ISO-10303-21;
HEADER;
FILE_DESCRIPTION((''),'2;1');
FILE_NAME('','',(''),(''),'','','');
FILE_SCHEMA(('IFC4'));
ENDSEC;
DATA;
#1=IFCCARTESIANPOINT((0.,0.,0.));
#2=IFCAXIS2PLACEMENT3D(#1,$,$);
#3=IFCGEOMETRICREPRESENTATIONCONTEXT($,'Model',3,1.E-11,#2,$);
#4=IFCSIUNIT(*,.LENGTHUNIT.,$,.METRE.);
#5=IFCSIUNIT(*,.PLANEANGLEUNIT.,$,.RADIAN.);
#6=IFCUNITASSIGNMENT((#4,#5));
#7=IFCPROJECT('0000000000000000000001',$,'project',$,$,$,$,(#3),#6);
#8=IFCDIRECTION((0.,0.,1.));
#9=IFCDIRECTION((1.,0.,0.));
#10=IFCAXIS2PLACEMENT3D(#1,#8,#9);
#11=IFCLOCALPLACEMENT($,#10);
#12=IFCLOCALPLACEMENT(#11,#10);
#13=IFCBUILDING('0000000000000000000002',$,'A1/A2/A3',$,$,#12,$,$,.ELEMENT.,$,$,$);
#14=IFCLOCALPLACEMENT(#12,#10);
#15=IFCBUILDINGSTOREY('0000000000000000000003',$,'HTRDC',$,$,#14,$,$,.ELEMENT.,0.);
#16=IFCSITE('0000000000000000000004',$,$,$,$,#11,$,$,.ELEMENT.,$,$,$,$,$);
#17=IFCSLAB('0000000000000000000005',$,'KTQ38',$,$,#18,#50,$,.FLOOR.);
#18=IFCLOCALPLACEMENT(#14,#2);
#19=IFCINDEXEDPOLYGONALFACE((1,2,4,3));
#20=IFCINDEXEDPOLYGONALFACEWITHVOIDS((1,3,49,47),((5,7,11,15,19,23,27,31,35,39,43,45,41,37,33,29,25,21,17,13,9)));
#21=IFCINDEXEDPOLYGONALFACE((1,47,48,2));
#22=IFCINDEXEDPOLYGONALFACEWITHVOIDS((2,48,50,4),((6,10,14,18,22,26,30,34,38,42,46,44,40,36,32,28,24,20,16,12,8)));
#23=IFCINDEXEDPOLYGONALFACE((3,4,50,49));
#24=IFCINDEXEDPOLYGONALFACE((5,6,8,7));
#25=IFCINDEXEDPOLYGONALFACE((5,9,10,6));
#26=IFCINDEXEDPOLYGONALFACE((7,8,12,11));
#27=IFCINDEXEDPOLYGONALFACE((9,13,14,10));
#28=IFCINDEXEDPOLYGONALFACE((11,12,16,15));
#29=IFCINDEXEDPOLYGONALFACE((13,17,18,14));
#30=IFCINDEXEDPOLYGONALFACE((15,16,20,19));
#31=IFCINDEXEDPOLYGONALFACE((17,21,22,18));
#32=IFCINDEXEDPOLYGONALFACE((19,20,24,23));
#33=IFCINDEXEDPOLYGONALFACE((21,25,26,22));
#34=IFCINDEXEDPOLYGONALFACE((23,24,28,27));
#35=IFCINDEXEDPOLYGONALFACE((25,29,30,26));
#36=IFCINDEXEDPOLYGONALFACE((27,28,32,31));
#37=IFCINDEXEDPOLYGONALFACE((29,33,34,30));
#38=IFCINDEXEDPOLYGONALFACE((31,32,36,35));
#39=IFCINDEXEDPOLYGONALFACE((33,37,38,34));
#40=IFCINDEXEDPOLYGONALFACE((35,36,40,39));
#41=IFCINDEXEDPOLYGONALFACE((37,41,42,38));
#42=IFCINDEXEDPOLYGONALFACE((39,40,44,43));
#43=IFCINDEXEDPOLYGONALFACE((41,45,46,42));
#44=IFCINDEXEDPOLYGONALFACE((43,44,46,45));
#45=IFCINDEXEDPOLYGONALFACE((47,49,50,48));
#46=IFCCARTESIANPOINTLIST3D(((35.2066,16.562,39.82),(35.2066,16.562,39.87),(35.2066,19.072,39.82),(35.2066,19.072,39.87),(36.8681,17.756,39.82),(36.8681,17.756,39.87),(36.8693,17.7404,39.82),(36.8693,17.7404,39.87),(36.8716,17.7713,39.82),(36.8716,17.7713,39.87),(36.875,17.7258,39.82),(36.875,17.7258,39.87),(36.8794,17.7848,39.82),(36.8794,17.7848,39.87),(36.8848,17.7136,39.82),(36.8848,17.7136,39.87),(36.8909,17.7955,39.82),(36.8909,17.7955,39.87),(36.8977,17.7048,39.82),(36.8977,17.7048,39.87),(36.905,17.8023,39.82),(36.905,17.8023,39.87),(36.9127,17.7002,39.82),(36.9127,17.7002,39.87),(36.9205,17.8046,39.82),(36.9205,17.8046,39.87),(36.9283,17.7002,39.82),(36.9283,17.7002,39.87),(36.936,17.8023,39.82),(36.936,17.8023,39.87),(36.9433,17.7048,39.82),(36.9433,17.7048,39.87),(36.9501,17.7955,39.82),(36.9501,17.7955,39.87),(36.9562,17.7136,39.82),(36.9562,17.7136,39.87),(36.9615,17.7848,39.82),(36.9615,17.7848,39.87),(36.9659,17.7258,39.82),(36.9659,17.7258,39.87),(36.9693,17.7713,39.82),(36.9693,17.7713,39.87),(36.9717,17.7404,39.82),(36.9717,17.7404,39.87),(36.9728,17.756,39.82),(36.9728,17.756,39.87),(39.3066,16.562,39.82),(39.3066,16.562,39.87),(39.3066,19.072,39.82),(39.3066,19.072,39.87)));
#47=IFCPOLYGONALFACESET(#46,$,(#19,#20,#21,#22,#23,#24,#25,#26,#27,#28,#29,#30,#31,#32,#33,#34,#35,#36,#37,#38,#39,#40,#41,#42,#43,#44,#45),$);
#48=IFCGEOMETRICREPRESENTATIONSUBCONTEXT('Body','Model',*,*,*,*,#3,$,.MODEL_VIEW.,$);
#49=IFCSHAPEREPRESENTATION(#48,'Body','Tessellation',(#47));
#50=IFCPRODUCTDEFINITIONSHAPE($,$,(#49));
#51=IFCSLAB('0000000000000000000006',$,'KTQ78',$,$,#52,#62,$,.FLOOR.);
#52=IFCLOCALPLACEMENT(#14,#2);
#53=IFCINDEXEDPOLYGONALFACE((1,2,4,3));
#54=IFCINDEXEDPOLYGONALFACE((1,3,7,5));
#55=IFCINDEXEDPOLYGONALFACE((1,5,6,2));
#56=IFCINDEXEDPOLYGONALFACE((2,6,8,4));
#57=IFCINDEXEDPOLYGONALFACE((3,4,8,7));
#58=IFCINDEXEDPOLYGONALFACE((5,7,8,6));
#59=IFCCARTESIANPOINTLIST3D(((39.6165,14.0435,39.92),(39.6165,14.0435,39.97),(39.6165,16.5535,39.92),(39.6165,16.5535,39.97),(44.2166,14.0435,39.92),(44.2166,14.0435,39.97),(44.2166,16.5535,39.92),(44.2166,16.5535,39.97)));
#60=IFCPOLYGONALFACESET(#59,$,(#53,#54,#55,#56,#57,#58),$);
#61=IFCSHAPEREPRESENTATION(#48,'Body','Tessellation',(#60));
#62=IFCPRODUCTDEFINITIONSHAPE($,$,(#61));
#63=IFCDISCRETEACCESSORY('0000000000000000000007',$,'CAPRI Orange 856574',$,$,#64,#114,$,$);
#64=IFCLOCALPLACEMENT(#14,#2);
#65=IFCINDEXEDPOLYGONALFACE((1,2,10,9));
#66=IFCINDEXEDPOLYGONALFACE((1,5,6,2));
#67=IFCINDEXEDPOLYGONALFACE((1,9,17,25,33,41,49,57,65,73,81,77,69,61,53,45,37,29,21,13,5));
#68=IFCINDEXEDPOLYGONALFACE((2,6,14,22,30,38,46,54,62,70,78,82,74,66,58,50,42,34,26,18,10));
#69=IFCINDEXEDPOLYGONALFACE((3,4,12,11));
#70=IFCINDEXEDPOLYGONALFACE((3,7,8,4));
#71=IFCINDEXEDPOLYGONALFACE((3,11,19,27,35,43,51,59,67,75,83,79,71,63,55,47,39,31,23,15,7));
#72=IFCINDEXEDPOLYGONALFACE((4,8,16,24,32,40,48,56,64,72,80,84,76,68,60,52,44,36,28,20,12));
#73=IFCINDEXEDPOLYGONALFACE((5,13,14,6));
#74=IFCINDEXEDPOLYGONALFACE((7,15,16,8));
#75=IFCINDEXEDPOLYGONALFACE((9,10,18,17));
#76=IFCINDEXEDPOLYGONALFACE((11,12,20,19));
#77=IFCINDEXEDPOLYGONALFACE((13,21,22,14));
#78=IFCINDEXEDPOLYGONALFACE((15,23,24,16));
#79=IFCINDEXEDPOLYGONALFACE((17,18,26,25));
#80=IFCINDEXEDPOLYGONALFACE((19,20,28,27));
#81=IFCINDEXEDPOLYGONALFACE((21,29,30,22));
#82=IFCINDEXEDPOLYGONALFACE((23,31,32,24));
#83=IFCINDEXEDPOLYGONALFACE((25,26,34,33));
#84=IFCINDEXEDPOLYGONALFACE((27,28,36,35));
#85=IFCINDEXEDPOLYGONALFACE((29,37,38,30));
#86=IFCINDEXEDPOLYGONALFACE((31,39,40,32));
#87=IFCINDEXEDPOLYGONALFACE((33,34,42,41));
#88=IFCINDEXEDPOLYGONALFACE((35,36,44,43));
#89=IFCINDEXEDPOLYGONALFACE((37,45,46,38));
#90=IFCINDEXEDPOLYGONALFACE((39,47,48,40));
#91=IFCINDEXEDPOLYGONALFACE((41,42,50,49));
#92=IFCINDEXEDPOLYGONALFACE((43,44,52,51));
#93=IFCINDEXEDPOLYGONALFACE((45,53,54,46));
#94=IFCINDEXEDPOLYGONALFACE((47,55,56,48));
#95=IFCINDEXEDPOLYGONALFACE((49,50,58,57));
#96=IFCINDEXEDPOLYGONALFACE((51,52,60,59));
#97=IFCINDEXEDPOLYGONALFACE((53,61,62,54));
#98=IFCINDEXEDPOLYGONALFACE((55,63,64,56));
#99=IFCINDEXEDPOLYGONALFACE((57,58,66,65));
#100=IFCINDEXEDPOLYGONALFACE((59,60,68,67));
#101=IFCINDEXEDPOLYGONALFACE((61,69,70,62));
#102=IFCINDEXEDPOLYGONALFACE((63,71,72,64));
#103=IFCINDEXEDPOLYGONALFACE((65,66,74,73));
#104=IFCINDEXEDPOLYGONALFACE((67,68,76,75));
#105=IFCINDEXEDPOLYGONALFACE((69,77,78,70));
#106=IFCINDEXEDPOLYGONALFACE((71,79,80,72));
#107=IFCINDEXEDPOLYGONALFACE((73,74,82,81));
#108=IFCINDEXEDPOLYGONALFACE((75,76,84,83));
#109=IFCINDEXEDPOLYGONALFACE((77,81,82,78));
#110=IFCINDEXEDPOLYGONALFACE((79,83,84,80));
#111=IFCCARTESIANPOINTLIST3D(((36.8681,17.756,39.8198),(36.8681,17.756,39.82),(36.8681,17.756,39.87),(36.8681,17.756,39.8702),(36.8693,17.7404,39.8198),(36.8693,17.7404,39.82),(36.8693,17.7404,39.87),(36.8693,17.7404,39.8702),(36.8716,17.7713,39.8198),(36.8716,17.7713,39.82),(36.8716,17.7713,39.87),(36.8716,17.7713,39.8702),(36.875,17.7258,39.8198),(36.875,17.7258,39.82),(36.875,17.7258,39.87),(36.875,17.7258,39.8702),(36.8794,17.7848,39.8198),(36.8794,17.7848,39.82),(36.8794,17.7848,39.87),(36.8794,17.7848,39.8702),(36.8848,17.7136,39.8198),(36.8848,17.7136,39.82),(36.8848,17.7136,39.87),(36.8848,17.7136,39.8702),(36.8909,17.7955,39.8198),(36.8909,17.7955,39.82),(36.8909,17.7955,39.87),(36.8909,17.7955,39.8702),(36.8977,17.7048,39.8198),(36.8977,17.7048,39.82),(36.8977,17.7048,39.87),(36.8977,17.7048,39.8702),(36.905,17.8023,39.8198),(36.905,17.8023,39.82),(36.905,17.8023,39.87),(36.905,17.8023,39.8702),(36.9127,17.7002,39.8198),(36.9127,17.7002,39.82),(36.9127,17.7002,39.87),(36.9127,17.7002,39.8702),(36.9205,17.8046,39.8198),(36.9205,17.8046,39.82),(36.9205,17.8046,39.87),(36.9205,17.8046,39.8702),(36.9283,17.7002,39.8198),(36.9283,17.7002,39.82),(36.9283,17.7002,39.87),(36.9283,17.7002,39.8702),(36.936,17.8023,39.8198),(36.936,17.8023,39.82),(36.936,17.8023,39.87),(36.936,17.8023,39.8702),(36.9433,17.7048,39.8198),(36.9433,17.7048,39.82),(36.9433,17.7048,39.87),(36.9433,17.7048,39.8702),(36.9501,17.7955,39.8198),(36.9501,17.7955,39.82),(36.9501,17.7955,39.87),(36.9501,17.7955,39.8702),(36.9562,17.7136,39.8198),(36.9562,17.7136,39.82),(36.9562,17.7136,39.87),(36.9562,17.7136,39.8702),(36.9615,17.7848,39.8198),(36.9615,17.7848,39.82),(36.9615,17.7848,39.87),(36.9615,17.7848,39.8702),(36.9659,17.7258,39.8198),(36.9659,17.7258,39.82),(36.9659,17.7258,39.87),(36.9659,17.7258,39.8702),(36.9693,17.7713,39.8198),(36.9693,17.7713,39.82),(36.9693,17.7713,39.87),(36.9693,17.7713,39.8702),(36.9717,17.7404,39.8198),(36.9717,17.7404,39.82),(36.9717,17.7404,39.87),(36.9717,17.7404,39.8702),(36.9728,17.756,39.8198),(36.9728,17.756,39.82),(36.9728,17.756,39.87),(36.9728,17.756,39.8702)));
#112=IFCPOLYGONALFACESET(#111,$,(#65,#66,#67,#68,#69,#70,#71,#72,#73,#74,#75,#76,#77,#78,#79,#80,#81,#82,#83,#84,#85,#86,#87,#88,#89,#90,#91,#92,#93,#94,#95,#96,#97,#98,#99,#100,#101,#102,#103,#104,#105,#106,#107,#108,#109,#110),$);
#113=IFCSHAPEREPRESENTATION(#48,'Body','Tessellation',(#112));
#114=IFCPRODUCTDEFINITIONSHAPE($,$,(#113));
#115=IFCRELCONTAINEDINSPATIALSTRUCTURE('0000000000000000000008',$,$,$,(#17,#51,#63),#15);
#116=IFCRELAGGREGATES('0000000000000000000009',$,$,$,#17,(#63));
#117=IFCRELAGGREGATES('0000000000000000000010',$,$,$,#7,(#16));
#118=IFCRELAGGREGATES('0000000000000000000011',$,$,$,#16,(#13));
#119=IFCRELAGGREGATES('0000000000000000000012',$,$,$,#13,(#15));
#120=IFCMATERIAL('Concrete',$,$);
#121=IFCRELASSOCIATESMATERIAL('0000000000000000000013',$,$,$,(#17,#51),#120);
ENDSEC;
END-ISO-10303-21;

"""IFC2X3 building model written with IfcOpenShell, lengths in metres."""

from ifc_helpers import new_model, si_unit, frame, frame_2d, origin, origin_with_axes, origin_2d_with_axis, place, context, subcontext, project, spatial, polyline, circle, outline, extrude, material, element, aggregate, save


model = new_model("IFC2X3")

# Units and contexts
model_context = context("Model", 3, precision=1e-11, world=origin())
body_context = subcontext(model_context, "Body", "Model", "MODEL_VIEW")
ifc_project = project(units=[si_unit("LENGTHUNIT", "METRE"), si_unit("PLANEANGLEUNIT", "RADIAN")], contexts=[model_context])

# Site, building, storey
site_placement = place(None, origin_with_axes())
site = spatial("IfcSite", under=ifc_project, at=site_placement, CompositionType="ELEMENT")
building_placement = place(site_placement, origin_with_axes())
building = spatial("IfcBuilding", under=site, at=building_placement, Name="A1/A2/A3", CompositionType="ELEMENT")
storey_placement = place(building_placement, origin_with_axes())
storey = spatial("IfcBuildingStorey", under=building, at=storey_placement, Name="HTRDC", CompositionType="ELEMENT", Elevation=0.0)

# Shared definitions
ifc_material = material(Name="Concrete")

# Slab, opening
slab_1_placement = place(storey_placement, frame((35.2066, 16.562, 39.82), z_axis=(0.0, 0.0, 1.0), x_axis=(1.0, 0.0, 0.0)))
slab_1 = element("IfcSlab", 1, at=slab_1_placement, inside=storey, material=ifc_material, Name="KTQ38", PredefinedType="FLOOR", context=body_context, shape_type="SweptSolid", body=[
    extrude(outline(polyline([(0.0, 0.0), (0.0, -4.1), (2.51, -4.1), (2.51, 0.0), (0.0, 0.0)])), frame((0.0, 0.0, 0.0), z_axis=(0.0, 0.0, 1.0), x_axis=(0.0, 1.0, 0.0)), (0.0, 0.0, 1.0), 0.05),
])
opening_1_placement = place(slab_1_placement, frame((1.7139, 1.1901, 0.0), z_axis=(0.0, 0.0, 1.0), x_axis=(1.0, 0.0, 0.0)))
element("IfcOpeningElement", 2, at=opening_1_placement, cuts=slab_1, ObjectType="Opening", context=body_context, shape_type="SweptSolid", body=[
    extrude(circle(Radius=0.0525, at=origin_2d_with_axis()), frame((0.0, 0.0, 0.0), z_axis=(0.0, 0.0, 1.0), x_axis=(0.0, 1.0, 0.0)), (0.0, 0.0, 1.0), 0.05),
])

# Slab
slab_2_placement = place(storey_placement, frame((39.6165, 14.0435, 39.92), z_axis=(0.0, 0.0, 1.0), x_axis=(1.0, 0.0, 0.0)))
element("IfcSlab", 3, at=slab_2_placement, inside=storey, material=ifc_material, Name="KTQ78", PredefinedType="FLOOR", context=body_context, shape_type="SweptSolid", body=[
    extrude(outline(polyline([(0.0, 0.0), (0.0, -4.6001), (2.51, -4.6001), (2.51, 0.0), (0.0, 0.0)])), frame((0.0, 0.0, 0.0), z_axis=(0.0, 0.0, 1.0), x_axis=(0.0, 1.0, 0.0)), (0.0, 0.0, 1.0), 0.05),
])

# Discrete accessory
discrete_accessory_1_placement = place(storey_placement, frame((35.2066, 16.562, 39.8199), z_axis=(0.0, 0.0, 1.0), x_axis=(1.0, 0.0, 0.0)))
discrete_accessory_1 = element("IfcDiscreteAccessory", 4, at=discrete_accessory_1_placement, inside=storey, Name="CAPRI Orange 856574", context=body_context, shape_type="SweptSolid", body=[
    extrude(circle(Radius=0.0525, at=frame_2d((1.1901, -1.7139), x_axis=(1.0, 0.0))), frame((0.0, 0.0, 0.0), z_axis=(0.0, 0.0, 1.0), x_axis=(0.0, 1.0, 0.0)), (0.0, 0.0, 1.0), 0.0503),
])
aggregate(slab_1, [discrete_accessory_1])

save(model, "model.ifc")
